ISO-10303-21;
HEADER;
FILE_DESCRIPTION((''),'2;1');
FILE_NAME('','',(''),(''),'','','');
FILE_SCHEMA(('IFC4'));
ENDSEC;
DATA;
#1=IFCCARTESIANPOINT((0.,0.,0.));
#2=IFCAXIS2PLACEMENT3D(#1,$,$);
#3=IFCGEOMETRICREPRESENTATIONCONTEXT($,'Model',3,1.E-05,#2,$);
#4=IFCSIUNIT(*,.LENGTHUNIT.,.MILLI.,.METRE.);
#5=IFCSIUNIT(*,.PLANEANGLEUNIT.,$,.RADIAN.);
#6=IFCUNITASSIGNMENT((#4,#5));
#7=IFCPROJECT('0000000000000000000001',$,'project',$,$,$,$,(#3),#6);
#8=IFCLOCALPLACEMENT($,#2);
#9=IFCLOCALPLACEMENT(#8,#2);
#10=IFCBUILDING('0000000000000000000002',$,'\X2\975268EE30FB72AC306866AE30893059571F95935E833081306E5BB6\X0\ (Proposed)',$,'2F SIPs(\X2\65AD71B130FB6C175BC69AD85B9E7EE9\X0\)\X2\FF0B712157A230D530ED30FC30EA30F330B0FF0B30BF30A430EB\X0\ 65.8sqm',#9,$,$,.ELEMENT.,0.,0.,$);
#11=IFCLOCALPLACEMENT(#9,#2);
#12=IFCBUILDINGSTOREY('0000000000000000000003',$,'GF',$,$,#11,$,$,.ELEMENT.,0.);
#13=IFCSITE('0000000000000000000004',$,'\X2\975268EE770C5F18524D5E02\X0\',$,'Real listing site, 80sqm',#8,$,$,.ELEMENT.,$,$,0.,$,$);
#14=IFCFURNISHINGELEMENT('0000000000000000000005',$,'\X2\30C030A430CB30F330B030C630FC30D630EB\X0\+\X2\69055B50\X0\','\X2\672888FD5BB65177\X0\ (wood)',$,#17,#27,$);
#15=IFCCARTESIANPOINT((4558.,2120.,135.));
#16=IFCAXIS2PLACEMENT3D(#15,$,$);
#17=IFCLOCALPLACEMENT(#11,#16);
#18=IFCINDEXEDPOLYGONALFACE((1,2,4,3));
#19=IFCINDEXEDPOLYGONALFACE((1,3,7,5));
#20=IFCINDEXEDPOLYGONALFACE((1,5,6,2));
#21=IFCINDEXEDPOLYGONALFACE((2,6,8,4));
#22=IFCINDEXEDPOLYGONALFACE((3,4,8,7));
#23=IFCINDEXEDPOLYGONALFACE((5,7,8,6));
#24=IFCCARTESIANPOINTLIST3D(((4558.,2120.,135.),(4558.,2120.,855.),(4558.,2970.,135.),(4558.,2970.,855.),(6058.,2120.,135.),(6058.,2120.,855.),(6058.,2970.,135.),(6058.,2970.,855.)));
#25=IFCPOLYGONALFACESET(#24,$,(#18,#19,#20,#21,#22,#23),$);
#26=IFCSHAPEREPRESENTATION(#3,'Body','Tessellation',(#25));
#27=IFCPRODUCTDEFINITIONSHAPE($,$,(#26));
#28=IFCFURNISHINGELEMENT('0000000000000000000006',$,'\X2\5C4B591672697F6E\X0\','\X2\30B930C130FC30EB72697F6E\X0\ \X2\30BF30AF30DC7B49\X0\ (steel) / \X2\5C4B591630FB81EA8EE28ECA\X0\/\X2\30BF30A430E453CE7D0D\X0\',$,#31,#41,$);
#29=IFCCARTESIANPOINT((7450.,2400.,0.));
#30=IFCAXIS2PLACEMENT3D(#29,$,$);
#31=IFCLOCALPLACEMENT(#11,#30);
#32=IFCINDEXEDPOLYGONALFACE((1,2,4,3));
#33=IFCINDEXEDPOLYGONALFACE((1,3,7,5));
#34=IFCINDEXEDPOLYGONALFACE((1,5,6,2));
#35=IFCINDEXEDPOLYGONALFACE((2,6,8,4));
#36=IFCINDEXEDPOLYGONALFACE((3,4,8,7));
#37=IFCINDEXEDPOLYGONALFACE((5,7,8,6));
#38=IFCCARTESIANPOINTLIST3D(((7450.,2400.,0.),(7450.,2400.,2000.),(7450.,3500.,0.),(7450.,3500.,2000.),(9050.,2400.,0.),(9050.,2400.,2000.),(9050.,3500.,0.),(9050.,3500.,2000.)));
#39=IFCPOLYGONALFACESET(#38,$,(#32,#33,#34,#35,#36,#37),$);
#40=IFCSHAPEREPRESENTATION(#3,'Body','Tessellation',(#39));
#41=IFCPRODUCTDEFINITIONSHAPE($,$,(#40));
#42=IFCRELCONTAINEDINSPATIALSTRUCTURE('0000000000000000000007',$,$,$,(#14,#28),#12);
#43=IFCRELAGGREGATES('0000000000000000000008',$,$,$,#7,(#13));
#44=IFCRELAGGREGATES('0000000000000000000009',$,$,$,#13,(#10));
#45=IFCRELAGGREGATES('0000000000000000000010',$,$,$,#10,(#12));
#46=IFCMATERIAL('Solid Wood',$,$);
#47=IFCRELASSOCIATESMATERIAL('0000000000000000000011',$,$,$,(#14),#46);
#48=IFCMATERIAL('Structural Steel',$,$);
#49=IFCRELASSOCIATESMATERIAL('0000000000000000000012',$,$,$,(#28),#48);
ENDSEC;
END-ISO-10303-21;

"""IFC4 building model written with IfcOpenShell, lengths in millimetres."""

from ifc_helpers import new_model, si_unit, frame, frame_2d, origin, place, context, project, spatial, rectangle, extrude, material, element, save


model = new_model("IFC4")

# Units and contexts
model_context = context("Model", 3, precision=1e-05, world=origin())
ifc_project = project(units=[si_unit("LENGTHUNIT", "METRE", prefix="MILLI"), si_unit("PLANEANGLEUNIT", "RADIAN")], contexts=[model_context])

# Site, building, storey
site_placement = place(None, origin())
site = spatial("IfcSite", under=ifc_project, at=site_placement, Name="青森県弘前市", ObjectType="Real listing site, 80sqm", CompositionType="ELEMENT", RefElevation=0.0)
building_placement = place(site_placement, origin())
building = spatial("IfcBuilding", under=site, at=building_placement, Name="青森・犬と暮らす土間広めの家 (Proposed)", ObjectType="2F SIPs(断熱・気密高实绩)＋無垢フローリング＋タイル 65.8sqm", CompositionType="ELEMENT", ElevationOfRefHeight=0.0, ElevationOfTerrain=0.0)
storey_placement = place(building_placement, origin())
storey = spatial("IfcBuildingStorey", under=building, at=storey_placement, Name="GF", CompositionType="ELEMENT", Elevation=0.0)

# Shared definitions
ifc_material_1 = material(Name="Solid Wood")

# Shared definitions
ifc_material_2 = material(Name="Structural Steel")

# Furnishing elements
furnishing_1_placement = place(storey_placement, frame((4558.0, 2120.0, 135.0)))
element("IfcFurnishingElement", 1, at=furnishing_1_placement, inside=storey, material=ifc_material_1, Name="ダイニングテーブル+椅子", Description="木製家具 (wood)", context=model_context, shape_type="SweptSolid", body=[
    extrude(rectangle(XDim=1500.0, YDim=850.0, at=frame_2d((750.0, 425.0))), frame((4558.0, 2120.0, 135.0)), (0.0, 0.0, 1.0), 720.0),
])
furnishing_2_placement = place(storey_placement, frame((7450.0, 2400.0, 0.0)))
element("IfcFurnishingElement", 2, at=furnishing_2_placement, inside=storey, material=ifc_material_2, Name="屋外物置", Description="スチール物置 タクボ等 (steel) / 屋外・自転車/タイヤ収納", context=model_context, shape_type="SweptSolid", body=[
    extrude(rectangle(XDim=1600.0, YDim=1100.0, at=frame_2d((800.0, 550.0))), frame((7450.0, 2400.0, 0.0)), (0.0, 0.0, 1.0), 2000.0),
])

save(model, "model.ifc")
